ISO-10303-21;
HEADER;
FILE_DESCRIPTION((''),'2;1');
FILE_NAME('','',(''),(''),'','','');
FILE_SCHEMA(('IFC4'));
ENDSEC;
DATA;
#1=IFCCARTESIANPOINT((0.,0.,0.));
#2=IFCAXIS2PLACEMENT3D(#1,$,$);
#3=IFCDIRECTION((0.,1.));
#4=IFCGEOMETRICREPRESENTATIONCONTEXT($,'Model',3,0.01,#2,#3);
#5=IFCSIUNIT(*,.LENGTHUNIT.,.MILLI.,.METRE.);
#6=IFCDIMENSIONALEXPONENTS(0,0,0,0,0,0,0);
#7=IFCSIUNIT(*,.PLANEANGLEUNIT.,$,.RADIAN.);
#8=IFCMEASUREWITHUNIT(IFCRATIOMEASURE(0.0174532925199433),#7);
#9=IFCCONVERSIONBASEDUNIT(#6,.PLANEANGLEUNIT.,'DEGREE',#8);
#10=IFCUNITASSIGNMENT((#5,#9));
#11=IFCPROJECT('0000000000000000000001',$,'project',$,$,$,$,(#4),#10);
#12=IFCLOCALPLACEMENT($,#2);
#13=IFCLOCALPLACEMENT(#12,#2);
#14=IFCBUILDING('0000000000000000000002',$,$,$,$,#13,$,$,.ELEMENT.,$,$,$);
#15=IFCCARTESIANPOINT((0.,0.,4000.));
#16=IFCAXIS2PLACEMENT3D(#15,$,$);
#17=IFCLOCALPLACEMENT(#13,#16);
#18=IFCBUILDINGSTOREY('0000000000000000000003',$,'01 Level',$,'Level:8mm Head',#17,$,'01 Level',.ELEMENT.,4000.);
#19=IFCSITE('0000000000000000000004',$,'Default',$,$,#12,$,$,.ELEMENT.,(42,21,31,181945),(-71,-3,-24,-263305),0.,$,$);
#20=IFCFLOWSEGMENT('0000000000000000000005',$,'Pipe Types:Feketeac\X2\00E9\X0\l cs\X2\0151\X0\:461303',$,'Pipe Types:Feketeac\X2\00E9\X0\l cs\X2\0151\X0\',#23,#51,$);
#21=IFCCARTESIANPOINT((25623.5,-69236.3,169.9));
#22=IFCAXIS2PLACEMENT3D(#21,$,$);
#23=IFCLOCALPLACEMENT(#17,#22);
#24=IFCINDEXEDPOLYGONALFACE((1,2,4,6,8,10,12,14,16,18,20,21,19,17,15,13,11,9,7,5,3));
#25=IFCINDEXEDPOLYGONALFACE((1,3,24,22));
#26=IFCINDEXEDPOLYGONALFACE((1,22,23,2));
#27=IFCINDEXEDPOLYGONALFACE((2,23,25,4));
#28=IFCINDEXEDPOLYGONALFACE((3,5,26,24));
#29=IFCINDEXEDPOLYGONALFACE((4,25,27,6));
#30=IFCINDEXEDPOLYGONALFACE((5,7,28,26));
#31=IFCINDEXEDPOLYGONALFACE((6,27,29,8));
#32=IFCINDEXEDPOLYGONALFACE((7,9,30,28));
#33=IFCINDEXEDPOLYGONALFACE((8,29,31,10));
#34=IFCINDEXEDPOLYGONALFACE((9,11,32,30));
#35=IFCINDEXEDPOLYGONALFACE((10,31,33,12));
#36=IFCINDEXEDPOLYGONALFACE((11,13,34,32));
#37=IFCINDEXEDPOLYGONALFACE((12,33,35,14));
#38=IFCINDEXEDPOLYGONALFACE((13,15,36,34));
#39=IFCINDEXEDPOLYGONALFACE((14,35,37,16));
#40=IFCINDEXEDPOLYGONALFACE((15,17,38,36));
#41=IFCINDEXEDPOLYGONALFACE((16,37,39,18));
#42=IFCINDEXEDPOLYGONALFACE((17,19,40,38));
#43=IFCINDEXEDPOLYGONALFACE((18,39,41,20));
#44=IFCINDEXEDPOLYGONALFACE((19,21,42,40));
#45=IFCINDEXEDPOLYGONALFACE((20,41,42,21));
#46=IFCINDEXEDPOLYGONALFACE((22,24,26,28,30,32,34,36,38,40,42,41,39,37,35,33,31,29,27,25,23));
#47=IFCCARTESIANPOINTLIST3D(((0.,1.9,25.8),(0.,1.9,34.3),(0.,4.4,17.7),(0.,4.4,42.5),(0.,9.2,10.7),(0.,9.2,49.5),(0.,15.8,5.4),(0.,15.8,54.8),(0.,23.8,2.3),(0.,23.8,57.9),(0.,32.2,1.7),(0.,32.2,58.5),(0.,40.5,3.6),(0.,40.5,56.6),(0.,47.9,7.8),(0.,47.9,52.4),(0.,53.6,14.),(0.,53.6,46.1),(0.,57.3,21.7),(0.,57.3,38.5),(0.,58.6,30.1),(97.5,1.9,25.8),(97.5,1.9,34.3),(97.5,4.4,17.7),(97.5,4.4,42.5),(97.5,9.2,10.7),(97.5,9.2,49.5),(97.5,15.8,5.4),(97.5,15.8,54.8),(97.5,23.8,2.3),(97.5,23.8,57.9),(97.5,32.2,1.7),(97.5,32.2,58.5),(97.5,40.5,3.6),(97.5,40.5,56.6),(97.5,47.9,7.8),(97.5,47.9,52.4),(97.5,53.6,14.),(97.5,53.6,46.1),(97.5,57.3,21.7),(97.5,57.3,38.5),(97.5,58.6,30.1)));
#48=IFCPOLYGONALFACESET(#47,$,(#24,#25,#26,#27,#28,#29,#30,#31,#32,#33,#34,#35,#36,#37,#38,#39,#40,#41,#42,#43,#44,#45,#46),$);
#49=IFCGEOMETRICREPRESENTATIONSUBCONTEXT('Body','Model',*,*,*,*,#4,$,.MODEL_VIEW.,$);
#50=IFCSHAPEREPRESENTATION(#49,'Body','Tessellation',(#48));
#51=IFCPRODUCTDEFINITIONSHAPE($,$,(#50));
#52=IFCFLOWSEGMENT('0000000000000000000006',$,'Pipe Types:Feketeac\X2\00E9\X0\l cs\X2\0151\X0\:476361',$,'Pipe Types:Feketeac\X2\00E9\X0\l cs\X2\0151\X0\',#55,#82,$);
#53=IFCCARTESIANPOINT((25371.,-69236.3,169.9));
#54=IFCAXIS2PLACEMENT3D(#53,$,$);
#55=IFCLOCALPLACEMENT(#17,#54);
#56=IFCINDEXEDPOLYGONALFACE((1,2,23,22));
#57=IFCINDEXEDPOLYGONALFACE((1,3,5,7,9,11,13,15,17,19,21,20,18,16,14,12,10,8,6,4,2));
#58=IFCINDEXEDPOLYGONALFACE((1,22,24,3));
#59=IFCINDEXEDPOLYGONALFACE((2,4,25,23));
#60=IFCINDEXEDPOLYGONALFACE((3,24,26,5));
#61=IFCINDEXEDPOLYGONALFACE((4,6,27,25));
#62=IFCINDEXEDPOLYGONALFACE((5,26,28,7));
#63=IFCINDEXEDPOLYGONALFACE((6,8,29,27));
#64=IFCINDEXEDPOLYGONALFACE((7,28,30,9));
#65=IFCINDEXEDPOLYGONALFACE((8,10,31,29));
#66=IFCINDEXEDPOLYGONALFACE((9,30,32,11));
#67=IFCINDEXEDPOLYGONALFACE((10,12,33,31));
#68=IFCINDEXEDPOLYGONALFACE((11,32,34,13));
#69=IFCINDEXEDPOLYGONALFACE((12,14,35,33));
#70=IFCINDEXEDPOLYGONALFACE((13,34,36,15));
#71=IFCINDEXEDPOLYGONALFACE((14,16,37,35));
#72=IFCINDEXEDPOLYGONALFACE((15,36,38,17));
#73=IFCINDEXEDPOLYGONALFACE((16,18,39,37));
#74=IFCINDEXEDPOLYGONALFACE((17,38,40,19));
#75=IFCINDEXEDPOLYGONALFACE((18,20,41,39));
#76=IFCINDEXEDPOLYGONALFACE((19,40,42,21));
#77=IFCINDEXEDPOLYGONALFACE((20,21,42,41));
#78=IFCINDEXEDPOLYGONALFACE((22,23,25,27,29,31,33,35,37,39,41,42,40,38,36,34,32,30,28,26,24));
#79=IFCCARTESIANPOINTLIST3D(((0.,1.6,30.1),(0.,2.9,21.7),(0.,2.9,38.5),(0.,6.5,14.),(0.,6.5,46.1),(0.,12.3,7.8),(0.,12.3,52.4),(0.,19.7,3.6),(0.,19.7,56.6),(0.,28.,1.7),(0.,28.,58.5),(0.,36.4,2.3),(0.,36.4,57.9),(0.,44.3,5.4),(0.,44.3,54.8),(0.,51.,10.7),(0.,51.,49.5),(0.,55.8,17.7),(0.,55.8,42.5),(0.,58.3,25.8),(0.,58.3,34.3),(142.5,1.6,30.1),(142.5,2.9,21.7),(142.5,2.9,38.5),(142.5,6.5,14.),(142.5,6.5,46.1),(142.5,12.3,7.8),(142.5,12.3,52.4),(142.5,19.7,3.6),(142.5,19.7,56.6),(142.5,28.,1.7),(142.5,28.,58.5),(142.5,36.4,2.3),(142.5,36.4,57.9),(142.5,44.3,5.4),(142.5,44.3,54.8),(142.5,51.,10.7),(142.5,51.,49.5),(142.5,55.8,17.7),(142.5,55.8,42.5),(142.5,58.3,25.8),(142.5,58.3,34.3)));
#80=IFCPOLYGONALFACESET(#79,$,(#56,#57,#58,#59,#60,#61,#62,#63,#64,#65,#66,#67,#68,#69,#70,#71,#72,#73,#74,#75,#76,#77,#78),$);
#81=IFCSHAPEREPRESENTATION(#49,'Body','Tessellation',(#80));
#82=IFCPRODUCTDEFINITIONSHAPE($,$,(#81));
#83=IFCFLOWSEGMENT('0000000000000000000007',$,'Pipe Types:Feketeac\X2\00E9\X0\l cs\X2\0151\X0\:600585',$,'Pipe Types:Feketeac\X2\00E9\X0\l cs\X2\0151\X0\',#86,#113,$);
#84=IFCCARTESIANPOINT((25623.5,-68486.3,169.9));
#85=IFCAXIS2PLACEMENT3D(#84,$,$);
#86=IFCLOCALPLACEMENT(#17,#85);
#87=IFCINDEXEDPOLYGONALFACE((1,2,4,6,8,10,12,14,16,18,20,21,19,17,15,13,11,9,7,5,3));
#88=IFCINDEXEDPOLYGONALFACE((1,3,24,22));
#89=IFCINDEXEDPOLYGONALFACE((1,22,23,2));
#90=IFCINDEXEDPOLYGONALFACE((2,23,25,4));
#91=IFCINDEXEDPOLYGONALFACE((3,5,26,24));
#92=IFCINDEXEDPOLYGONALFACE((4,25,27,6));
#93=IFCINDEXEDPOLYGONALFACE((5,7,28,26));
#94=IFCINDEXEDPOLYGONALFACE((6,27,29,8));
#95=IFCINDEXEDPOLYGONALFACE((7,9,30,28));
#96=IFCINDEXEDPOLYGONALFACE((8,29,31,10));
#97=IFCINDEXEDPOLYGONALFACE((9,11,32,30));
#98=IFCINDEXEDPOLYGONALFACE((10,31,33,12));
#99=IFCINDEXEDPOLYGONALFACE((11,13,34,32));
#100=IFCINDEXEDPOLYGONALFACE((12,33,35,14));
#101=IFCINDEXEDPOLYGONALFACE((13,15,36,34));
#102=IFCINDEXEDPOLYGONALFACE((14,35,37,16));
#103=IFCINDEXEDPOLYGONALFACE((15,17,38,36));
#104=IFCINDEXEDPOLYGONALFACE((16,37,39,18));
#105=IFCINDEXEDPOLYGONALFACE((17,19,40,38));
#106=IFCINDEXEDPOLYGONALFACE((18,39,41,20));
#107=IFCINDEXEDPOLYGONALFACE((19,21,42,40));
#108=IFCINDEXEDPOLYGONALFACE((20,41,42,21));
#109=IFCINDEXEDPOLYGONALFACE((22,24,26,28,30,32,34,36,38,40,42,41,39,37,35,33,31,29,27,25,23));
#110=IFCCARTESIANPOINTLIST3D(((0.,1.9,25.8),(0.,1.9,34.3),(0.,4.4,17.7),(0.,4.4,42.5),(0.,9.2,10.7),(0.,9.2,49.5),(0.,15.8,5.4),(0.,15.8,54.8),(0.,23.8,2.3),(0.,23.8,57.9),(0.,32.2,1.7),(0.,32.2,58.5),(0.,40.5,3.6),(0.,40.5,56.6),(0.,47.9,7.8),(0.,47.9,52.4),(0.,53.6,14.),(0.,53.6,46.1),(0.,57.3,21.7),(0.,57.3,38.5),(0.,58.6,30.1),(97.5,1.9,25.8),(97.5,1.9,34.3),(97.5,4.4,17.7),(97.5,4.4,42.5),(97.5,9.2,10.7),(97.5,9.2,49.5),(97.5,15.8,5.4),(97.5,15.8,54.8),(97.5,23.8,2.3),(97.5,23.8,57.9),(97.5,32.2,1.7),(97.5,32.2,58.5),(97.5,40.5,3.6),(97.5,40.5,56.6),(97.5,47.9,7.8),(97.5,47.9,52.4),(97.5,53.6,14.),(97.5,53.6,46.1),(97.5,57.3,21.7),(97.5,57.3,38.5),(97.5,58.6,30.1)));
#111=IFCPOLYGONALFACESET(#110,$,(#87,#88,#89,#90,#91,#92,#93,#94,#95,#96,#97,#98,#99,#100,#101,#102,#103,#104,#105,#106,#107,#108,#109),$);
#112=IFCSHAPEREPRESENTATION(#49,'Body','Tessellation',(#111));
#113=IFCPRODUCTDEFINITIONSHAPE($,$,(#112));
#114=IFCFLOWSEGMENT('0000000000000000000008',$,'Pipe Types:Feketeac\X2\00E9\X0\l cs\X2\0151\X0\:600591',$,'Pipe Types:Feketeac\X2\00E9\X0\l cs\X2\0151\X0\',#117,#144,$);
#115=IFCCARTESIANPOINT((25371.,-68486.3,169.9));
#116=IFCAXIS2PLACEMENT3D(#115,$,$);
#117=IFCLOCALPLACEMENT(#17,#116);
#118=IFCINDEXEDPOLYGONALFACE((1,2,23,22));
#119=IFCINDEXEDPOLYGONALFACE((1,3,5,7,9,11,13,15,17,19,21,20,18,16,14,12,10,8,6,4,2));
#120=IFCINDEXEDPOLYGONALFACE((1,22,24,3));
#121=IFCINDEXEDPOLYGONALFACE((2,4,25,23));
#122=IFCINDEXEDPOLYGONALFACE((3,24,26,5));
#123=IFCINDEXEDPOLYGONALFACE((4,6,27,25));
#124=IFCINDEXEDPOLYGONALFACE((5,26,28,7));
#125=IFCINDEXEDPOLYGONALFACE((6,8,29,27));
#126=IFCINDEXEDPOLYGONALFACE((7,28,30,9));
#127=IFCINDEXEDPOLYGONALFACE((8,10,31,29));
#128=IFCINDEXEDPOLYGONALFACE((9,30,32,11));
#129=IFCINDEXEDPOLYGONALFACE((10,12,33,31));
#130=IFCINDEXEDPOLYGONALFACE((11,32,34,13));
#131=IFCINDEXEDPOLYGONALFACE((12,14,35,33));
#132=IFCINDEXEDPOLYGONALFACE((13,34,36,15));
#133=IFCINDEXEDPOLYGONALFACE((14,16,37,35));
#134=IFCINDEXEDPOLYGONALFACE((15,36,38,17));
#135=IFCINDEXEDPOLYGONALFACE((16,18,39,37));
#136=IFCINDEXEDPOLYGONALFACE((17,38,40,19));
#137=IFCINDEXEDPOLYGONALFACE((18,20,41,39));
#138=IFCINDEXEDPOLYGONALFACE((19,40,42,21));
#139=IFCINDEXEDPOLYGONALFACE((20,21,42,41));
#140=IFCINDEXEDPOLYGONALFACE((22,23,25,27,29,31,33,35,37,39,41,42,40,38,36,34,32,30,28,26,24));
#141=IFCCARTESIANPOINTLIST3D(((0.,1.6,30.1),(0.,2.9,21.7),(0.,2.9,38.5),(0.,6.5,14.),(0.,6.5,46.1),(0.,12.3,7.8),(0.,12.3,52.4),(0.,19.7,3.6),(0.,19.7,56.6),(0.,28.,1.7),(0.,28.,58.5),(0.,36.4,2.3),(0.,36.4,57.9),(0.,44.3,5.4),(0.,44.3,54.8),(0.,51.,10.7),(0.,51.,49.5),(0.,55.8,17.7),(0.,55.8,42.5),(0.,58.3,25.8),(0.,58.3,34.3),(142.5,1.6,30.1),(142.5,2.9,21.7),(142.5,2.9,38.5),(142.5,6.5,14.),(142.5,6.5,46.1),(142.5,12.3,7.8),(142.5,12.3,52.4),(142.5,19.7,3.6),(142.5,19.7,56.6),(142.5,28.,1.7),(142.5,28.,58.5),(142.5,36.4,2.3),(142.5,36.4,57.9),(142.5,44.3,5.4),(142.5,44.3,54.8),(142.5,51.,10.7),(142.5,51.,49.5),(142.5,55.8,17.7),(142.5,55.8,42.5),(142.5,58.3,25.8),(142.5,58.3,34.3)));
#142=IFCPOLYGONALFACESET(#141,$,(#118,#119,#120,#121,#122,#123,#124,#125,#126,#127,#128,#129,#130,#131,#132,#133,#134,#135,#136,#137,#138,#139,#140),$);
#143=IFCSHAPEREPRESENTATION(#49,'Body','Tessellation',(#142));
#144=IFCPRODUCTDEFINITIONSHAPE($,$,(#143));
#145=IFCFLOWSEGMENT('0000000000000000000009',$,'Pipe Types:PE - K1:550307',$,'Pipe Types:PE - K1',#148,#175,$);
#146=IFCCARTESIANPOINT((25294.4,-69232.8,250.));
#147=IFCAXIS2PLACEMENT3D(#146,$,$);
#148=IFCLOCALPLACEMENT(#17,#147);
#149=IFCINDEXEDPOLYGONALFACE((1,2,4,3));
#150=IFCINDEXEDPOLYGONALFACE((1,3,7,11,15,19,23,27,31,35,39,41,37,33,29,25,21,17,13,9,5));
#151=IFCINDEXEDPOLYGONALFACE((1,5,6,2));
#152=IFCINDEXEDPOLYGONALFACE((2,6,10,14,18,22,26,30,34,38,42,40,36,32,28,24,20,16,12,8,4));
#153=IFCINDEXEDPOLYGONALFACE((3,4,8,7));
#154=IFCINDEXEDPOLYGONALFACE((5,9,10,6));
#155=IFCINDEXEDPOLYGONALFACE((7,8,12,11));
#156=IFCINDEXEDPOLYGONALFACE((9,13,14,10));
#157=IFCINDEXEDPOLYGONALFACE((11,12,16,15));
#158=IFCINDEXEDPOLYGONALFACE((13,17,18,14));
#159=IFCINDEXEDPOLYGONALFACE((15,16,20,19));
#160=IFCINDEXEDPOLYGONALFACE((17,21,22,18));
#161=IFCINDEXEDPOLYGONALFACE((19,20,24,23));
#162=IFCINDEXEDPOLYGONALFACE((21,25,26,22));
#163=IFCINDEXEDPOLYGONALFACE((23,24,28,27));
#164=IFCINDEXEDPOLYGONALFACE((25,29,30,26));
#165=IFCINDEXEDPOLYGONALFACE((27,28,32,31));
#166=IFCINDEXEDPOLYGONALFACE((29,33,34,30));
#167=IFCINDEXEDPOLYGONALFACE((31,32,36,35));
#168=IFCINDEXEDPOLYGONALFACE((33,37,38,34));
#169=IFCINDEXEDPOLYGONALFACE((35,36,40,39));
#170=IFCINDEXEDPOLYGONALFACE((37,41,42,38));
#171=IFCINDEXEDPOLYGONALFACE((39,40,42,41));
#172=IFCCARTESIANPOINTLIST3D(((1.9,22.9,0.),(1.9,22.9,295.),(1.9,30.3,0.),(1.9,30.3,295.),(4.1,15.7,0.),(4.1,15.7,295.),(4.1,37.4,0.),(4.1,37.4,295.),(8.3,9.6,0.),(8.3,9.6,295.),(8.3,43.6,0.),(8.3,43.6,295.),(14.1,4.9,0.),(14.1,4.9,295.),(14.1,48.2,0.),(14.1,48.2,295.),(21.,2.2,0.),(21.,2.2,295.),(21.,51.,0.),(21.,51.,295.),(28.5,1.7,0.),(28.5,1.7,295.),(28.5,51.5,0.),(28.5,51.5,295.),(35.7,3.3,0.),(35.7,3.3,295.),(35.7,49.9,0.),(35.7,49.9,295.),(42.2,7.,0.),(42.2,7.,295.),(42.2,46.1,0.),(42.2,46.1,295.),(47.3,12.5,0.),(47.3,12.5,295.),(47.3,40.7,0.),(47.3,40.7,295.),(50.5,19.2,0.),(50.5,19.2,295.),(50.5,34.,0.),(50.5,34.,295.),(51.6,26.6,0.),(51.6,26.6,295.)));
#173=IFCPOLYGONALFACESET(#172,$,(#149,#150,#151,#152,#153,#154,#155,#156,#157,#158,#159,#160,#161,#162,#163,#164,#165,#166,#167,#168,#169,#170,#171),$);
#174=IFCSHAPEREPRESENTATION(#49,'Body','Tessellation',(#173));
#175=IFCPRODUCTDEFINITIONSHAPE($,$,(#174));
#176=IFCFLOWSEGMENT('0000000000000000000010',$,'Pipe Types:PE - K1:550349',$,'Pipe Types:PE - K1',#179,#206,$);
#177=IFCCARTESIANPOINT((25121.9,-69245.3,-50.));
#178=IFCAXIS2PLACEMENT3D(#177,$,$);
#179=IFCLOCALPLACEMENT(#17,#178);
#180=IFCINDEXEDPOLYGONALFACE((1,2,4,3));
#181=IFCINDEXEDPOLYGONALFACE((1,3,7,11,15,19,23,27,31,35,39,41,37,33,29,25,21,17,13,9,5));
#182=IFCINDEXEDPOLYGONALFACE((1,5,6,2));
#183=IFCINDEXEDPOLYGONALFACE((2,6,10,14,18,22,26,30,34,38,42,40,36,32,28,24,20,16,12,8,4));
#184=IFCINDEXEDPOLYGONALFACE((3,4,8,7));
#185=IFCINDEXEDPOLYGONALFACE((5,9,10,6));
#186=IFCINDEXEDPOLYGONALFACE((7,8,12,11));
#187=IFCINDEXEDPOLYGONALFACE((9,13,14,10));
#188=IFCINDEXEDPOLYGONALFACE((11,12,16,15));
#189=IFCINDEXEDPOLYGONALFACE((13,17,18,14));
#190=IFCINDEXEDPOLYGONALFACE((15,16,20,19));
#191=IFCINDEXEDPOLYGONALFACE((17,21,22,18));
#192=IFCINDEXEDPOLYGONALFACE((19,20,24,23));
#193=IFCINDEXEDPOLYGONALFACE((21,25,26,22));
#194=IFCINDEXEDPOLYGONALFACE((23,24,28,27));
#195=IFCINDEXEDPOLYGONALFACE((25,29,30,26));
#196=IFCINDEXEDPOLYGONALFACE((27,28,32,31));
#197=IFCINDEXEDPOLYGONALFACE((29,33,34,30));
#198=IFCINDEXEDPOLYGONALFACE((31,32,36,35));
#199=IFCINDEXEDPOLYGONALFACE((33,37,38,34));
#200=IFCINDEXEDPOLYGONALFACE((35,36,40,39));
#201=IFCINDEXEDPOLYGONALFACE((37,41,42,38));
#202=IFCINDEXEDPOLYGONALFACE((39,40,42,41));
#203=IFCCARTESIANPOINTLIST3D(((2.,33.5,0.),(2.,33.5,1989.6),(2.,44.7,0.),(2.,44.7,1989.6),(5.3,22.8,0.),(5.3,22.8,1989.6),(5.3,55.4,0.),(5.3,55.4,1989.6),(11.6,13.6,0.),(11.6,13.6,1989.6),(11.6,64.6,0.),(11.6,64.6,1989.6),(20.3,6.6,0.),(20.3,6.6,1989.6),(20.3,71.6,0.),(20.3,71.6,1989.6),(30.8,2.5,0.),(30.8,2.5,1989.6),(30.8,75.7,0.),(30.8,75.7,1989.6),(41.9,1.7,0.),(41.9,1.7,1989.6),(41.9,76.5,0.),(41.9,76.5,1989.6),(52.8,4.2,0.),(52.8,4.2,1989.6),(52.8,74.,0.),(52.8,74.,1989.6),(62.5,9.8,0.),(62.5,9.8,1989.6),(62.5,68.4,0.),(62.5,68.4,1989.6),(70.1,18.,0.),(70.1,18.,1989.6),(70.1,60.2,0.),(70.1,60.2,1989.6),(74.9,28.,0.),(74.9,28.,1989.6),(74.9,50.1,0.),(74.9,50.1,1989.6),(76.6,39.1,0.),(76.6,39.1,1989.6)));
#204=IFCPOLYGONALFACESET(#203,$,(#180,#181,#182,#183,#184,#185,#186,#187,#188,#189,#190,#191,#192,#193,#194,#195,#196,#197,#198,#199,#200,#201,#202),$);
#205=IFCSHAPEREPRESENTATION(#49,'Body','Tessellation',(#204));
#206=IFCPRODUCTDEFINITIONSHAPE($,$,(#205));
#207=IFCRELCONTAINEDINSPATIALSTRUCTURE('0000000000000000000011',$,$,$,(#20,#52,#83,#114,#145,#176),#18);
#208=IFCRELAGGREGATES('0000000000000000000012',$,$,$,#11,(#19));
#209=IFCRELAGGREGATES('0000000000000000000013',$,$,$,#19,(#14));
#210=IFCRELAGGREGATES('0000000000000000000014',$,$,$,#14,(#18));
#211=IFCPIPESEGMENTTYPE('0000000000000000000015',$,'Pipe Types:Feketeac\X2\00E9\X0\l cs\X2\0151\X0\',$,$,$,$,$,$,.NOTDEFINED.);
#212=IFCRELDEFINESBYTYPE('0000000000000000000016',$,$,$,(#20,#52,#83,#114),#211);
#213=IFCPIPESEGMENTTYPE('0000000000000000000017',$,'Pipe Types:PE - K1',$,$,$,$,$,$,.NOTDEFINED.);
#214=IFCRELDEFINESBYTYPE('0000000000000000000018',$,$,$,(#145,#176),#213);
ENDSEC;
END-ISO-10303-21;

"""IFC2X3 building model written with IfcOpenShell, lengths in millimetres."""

from ifc_helpers import new_model, entity, si_unit, converted_unit, direction, frame, frame_2d, origin, origin_2d_with_axis, place, context, subcontext, project, spatial, circle, extrude, type_object, element, save


model = new_model("IFC2X3")

# Units and contexts
model_context = context("Model", 3, precision=0.01, world=origin(), true_north=direction((0.0, 1.0)))
body_context = subcontext(model_context, "Body", "Model", "MODEL_VIEW")
ifc_project = project(units=[si_unit("LENGTHUNIT", "METRE", prefix="MILLI"), converted_unit("PLANEANGLEUNIT", "DEGREE", entity("IfcRatioMeasure", 0.0174532925199433), si_unit("PLANEANGLEUNIT", "RADIAN"), dimensions=[0, 0, 0, 0, 0, 0, 0])], contexts=[model_context])

# Site, building, storey
site_placement = place(None, origin())
site = spatial("IfcSite", under=ifc_project, at=site_placement, Name="Default", CompositionType="ELEMENT", RefLatitude=(42, 21, 31, 181945), RefLongitude=(-71, -3, -24, -263305), RefElevation=0.0)
building_placement = place(site_placement, origin())
building = spatial("IfcBuilding", under=site, at=building_placement, CompositionType="ELEMENT")
storey_placement = place(building_placement, frame((0.0, 0.0, 4000.0)))
storey = spatial("IfcBuildingStorey", under=building, at=storey_placement, Name="01 Level", ObjectType="Level:8mm Head", LongName="01 Level", CompositionType="ELEMENT", Elevation=4000.0)

# Flow segments
pipe_segment_type_1 = type_object("IfcPipeSegmentType", Name="Pipe Types:Feketeacél cső", PredefinedType="NOTDEFINED")
flow_segment_1_placement = place(storey_placement, frame((25623.5, -69236.3, 169.9)))
element("IfcFlowSegment", 1, at=flow_segment_1_placement, inside=storey, type_object=pipe_segment_type_1, Name="Pipe Types:Feketeacél cső:461303", ObjectType="Pipe Types:Feketeacél cső", context=body_context, shape_type="SweptSolid", body=[
    extrude(circle(Radius=28.5, at=frame_2d((0.0, 0.0), x_axis=(1.0, 0.0))), frame((0.0, 30.1, 30.1), z_axis=(1.0, 0.0, 0.0), x_axis=(0.0, 1.0, 0.0)), (0.0, 0.0, 1.0), 97.5),
])
flow_segment_2_placement = place(storey_placement, frame((25371.0, -69236.3, 169.9)))
element("IfcFlowSegment", 2, at=flow_segment_2_placement, inside=storey, type_object=pipe_segment_type_1, Name="Pipe Types:Feketeacél cső:476361", ObjectType="Pipe Types:Feketeacél cső", context=body_context, shape_type="SweptSolid", body=[
    extrude(circle(Radius=28.5, at=origin_2d_with_axis()), frame((0.0, 30.1, 30.1), z_axis=(1.0, 0.0, 0.0), x_axis=(0.0, -1.0, 0.0)), (0.0, 0.0, 1.0), 142.5),
])
flow_segment_3_placement = place(storey_placement, frame((25623.5, -68486.3, 169.9)))
element("IfcFlowSegment", 3, at=flow_segment_3_placement, inside=storey, type_object=pipe_segment_type_1, Name="Pipe Types:Feketeacél cső:600585", ObjectType="Pipe Types:Feketeacél cső", context=body_context, shape_type="SweptSolid", body=[
    extrude(circle(Radius=28.5, at=frame_2d((0.0, 0.0), x_axis=(1.0, 0.0))), frame((0.0, 30.1, 30.1), z_axis=(1.0, 0.0, 0.0), x_axis=(0.0, 1.0, 0.0)), (0.0, 0.0, 1.0), 97.5),
])
flow_segment_4_placement = place(storey_placement, frame((25371.0, -68486.3, 169.9)))
element("IfcFlowSegment", 4, at=flow_segment_4_placement, inside=storey, type_object=pipe_segment_type_1, Name="Pipe Types:Feketeacél cső:600591", ObjectType="Pipe Types:Feketeacél cső", context=body_context, shape_type="SweptSolid", body=[
    extrude(circle(Radius=28.5, at=origin_2d_with_axis()), frame((0.0, 30.1, 30.1), z_axis=(1.0, 0.0, 0.0), x_axis=(0.0, -1.0, 0.0)), (0.0, 0.0, 1.0), 142.5),
])
pipe_segment_type_2 = type_object("IfcPipeSegmentType", Name="Pipe Types:PE - K1", PredefinedType="NOTDEFINED")
flow_segment_5_placement = place(storey_placement, frame((25294.4, -69232.8, 250.0)))
element("IfcFlowSegment", 5, at=flow_segment_5_placement, inside=storey, type_object=pipe_segment_type_2, Name="Pipe Types:PE - K1:550307", ObjectType="Pipe Types:PE - K1", context=body_context, shape_type="SweptSolid", body=[
    extrude(circle(Radius=25.0, at=frame_2d((0.0, 0.0), x_axis=(1.0, 0.0))), frame((26.6, 26.6, 0.0)), (0.0, 0.0, 1.0), 295.0),
])
flow_segment_6_placement = place(storey_placement, frame((25121.9, -69245.3, -50.0)))
element("IfcFlowSegment", 6, at=flow_segment_6_placement, inside=storey, type_object=pipe_segment_type_2, Name="Pipe Types:PE - K1:550349", ObjectType="Pipe Types:PE - K1", context=body_context, shape_type="SweptSolid", body=[
    extrude(circle(Radius=37.5, at=origin_2d_with_axis()), frame((39.1, 39.1, 0.0)), (0.0, 0.0, 1.0), 1989.6),
])

save(model, "model.ifc")
